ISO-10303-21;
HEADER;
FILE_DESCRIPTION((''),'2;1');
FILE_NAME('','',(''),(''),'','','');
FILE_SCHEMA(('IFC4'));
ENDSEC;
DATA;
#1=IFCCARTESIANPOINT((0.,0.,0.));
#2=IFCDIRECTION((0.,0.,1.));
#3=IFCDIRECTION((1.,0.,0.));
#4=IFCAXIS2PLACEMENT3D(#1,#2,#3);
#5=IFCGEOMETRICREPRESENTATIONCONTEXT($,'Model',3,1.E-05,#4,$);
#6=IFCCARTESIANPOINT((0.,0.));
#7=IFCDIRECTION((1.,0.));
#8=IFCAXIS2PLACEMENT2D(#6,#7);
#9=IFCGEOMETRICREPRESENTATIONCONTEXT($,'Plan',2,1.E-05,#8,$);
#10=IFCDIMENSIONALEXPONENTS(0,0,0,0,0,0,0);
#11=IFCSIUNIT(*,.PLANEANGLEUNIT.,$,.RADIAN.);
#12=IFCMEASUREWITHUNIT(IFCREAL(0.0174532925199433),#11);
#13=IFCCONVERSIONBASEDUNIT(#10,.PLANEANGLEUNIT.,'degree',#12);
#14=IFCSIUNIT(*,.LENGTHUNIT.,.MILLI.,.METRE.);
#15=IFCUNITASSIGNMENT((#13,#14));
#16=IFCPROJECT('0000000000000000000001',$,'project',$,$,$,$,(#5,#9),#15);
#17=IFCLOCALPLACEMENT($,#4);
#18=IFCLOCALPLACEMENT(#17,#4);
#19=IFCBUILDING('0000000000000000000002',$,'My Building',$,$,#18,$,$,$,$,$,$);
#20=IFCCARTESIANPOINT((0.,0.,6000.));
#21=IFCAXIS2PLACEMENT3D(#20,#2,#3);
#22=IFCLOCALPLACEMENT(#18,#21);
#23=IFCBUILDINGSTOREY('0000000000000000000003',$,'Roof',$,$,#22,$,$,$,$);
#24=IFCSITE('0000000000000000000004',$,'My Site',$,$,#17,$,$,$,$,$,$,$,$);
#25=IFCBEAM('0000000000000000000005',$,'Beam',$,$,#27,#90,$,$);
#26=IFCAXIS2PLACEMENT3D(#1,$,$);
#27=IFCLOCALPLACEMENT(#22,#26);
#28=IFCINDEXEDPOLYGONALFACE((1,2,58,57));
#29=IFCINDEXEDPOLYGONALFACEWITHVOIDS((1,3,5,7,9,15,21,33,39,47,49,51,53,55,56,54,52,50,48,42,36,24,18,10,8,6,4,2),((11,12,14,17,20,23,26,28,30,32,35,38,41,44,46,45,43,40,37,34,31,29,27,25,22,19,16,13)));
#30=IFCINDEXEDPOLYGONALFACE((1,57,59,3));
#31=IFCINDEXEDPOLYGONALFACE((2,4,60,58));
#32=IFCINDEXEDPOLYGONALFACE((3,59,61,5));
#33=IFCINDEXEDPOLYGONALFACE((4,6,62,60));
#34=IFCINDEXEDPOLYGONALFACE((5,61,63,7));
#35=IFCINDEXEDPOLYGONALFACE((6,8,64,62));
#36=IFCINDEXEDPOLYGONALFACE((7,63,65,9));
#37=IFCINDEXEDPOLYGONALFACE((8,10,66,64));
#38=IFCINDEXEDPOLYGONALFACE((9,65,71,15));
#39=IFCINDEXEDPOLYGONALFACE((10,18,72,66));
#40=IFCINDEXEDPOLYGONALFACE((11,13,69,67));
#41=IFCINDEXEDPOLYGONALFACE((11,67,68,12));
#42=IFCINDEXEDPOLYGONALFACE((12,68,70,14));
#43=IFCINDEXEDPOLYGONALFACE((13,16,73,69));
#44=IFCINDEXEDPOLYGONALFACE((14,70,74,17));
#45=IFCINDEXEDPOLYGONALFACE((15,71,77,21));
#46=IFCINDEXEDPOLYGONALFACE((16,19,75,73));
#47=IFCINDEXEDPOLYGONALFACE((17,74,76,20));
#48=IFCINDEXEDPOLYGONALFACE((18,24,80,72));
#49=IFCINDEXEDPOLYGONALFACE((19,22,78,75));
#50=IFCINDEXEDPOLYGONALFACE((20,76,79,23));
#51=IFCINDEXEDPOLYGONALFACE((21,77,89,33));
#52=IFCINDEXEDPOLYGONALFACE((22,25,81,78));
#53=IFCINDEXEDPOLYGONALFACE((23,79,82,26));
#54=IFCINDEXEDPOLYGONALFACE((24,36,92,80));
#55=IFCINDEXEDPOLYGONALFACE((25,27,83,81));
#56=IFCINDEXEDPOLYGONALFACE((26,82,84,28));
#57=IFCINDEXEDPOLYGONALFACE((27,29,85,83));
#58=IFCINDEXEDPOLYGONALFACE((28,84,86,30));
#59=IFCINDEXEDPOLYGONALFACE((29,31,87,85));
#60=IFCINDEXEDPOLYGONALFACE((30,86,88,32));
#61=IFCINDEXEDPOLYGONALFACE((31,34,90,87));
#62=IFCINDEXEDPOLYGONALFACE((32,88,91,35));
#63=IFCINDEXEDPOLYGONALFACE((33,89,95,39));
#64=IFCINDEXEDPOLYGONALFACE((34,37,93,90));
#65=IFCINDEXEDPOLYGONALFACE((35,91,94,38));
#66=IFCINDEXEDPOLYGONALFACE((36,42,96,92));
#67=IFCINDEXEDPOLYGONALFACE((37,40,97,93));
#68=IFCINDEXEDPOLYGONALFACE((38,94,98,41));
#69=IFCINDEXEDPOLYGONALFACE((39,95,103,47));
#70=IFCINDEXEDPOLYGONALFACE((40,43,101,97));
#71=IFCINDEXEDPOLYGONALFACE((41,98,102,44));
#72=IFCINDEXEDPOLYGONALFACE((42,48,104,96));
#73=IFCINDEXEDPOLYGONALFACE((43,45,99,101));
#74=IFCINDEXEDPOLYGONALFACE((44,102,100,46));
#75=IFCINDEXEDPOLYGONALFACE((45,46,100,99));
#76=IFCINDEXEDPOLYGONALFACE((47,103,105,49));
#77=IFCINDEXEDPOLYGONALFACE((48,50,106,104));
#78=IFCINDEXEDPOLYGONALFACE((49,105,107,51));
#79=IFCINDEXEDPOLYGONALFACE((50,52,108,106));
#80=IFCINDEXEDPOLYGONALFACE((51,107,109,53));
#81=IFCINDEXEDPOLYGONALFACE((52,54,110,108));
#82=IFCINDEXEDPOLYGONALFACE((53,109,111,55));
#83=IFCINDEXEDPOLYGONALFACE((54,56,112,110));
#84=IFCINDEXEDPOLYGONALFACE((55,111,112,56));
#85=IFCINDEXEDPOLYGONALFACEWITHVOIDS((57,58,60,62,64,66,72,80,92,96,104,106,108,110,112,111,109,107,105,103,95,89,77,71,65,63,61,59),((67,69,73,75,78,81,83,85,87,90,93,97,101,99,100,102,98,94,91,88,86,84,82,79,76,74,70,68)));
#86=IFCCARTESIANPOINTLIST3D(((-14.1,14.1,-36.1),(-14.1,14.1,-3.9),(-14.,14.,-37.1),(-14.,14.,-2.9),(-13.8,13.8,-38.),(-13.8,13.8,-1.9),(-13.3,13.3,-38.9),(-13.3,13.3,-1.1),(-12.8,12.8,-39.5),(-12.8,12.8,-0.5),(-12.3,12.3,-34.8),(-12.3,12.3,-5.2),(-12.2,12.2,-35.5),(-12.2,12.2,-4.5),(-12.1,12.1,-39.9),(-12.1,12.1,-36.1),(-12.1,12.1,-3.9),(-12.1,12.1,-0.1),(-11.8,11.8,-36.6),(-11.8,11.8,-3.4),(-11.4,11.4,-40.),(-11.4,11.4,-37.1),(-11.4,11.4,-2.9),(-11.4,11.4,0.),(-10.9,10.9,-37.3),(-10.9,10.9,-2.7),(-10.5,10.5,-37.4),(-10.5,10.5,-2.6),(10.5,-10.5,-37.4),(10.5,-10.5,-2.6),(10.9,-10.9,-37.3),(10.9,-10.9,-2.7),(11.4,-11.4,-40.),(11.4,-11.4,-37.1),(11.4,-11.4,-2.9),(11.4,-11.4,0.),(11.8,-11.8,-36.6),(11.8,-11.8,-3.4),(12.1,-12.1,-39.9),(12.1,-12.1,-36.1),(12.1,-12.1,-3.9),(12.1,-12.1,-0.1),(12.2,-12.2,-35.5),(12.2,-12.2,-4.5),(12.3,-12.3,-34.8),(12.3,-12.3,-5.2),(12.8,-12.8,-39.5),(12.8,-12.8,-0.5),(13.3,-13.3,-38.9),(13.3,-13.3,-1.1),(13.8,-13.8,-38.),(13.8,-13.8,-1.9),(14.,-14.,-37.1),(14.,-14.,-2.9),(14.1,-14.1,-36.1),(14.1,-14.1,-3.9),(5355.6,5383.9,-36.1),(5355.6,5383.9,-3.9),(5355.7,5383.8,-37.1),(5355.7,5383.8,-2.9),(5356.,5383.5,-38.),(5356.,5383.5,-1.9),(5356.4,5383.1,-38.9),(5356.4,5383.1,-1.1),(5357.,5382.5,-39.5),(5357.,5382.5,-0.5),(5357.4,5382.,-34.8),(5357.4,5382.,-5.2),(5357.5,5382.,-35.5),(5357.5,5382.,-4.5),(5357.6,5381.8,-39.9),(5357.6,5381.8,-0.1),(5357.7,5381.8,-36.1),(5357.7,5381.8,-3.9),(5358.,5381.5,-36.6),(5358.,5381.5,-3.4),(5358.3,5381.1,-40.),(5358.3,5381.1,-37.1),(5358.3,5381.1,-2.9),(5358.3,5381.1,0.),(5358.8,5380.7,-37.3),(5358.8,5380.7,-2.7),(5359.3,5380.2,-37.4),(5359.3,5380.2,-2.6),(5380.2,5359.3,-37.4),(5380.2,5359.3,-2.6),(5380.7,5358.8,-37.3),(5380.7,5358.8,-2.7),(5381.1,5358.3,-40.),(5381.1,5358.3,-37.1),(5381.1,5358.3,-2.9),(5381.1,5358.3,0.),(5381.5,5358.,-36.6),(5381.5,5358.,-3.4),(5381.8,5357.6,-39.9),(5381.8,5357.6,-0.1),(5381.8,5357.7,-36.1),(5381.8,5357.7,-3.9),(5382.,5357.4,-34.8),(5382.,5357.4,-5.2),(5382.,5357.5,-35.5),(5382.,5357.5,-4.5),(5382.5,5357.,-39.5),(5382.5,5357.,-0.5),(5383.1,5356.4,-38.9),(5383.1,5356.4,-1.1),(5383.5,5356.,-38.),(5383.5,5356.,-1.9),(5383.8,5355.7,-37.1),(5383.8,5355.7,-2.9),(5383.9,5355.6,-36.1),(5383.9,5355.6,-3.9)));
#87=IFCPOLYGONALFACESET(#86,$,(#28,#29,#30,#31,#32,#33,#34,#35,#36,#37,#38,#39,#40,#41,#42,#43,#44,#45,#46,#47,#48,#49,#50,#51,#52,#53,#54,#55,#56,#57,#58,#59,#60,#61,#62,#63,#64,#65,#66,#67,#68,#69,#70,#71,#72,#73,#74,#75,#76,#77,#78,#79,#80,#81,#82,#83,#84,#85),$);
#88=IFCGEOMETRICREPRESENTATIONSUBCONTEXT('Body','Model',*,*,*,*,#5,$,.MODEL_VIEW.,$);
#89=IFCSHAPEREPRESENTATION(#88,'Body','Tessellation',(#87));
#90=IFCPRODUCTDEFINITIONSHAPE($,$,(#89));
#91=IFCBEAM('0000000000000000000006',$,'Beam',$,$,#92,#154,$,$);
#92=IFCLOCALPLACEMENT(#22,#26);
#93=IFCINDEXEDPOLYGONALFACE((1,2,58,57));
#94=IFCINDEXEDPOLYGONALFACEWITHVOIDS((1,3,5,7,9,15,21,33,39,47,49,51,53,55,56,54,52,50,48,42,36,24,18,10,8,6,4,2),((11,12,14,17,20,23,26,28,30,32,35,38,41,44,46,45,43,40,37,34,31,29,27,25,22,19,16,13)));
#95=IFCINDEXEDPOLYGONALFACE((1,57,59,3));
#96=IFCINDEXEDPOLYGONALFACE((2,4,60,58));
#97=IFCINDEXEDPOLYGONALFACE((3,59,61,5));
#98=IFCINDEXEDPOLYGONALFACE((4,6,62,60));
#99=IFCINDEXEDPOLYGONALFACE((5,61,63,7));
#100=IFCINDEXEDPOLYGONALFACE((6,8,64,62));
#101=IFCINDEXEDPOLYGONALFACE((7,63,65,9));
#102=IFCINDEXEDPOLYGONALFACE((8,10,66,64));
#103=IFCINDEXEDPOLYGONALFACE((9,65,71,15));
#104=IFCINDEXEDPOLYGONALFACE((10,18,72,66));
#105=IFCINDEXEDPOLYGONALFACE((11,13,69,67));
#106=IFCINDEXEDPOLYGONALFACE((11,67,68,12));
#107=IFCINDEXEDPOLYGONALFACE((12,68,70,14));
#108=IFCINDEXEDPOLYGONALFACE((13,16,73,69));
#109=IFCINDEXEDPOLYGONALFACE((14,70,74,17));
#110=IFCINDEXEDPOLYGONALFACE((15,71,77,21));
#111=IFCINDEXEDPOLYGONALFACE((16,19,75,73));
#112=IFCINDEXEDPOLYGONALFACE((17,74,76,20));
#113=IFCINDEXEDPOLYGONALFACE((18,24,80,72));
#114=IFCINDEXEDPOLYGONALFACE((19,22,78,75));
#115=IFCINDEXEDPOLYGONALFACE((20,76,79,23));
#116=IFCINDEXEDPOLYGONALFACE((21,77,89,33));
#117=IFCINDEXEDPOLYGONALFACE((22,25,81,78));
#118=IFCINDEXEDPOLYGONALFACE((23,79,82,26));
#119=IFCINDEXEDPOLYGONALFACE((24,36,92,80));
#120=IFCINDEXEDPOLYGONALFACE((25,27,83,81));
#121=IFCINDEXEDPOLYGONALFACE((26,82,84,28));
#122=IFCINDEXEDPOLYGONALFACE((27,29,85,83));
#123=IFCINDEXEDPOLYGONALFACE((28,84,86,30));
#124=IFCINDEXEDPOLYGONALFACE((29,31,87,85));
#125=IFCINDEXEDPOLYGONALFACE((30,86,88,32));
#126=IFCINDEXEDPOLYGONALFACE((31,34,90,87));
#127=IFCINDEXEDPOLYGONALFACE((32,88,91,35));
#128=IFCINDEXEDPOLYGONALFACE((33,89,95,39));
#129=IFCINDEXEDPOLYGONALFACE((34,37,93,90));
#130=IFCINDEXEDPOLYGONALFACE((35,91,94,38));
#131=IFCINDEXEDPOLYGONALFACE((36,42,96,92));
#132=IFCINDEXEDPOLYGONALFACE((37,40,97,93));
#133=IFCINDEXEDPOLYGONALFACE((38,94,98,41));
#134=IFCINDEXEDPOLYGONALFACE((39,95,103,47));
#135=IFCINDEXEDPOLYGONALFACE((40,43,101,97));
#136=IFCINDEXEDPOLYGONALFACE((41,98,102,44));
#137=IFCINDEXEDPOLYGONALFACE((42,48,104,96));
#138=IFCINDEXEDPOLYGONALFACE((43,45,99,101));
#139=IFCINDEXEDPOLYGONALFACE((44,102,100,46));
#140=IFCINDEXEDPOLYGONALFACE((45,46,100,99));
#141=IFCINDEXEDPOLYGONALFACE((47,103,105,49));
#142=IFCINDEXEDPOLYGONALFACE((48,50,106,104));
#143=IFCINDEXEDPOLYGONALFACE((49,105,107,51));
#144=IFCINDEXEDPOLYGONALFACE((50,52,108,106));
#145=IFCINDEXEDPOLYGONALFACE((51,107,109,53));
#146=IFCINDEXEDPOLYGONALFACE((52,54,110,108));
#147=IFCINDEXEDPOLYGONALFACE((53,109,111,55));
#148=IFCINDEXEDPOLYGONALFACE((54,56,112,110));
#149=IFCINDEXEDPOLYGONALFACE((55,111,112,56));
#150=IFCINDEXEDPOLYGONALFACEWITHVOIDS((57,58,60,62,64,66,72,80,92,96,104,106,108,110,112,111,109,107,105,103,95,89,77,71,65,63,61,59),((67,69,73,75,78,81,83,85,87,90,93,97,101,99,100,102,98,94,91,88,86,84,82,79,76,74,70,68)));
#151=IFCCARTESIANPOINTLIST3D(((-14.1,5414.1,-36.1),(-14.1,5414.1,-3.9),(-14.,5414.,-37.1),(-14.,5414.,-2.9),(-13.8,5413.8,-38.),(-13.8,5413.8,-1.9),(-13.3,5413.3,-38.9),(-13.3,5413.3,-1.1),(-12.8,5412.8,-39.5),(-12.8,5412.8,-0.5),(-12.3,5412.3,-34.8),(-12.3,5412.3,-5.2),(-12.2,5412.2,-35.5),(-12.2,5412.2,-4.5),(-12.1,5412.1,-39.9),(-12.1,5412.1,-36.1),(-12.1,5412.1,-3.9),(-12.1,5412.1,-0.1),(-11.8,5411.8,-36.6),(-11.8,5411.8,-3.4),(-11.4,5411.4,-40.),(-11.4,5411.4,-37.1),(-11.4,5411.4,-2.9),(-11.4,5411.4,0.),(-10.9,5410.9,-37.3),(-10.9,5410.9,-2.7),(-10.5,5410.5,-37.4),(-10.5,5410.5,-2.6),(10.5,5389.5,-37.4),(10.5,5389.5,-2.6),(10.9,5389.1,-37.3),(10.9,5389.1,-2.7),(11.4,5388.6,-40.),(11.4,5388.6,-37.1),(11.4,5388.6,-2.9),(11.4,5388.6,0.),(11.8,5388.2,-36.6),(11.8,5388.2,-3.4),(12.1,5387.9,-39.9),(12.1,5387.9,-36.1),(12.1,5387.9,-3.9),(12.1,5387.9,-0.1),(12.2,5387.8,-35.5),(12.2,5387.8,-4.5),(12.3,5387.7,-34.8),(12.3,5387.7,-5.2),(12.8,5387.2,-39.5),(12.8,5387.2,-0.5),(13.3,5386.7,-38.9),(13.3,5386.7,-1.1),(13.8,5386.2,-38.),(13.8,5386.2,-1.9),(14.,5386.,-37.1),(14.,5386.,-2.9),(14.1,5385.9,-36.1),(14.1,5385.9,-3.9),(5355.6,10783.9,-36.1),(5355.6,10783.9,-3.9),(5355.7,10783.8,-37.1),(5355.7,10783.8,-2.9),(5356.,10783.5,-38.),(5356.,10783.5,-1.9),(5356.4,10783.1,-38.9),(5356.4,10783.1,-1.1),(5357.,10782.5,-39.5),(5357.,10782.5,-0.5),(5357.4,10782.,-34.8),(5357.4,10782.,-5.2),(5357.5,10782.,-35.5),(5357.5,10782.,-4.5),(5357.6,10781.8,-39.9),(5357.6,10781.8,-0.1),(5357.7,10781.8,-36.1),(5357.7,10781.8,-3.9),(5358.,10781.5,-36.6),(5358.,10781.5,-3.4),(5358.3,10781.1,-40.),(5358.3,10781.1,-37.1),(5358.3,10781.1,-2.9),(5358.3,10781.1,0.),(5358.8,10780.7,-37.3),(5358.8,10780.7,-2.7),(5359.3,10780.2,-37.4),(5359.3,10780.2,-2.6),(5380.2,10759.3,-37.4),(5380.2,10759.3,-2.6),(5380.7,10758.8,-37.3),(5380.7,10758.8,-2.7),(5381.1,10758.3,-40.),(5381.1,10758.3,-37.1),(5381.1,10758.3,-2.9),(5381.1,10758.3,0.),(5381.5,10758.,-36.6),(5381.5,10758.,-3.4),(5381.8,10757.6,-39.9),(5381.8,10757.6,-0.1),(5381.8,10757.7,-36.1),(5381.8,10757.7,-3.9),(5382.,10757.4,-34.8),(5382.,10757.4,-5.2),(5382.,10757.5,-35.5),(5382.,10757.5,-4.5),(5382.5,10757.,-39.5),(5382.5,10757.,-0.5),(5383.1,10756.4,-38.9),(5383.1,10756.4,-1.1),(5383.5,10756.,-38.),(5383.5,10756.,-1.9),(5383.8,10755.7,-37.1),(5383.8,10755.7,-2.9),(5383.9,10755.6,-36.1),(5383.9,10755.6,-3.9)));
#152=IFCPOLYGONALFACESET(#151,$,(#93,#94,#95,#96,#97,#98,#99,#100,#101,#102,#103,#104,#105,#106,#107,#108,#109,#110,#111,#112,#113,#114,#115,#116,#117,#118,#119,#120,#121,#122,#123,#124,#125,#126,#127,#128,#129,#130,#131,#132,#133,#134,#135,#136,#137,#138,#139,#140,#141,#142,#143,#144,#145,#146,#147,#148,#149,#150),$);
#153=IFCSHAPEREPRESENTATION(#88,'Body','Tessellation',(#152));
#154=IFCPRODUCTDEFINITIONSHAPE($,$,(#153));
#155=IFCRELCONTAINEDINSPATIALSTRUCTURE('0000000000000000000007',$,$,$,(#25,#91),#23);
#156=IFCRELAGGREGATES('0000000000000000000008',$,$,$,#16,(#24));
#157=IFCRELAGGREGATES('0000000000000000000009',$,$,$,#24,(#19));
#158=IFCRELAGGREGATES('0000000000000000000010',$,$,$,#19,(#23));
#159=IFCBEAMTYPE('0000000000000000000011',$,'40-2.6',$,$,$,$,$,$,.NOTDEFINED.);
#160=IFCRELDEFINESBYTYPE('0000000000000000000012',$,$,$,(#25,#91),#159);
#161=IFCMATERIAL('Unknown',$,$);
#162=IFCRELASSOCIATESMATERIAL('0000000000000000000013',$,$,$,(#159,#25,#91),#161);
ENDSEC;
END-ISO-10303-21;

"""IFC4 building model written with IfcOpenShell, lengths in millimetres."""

from ifc_helpers import new_model, entity, si_unit, converted_unit, frame, origin_with_axes, origin_2d_with_axis, place, context, subcontext, project, spatial, hollow_rectangle, extrude, material, material_profile, profile_set, profile_usage, type_object, element, save


model = new_model("IFC4")

# Units and contexts
model_context = context("Model", 3, precision=1e-05, world=origin_with_axes())
plan_context = context("Plan", 2, precision=1e-05, world=origin_2d_with_axis())
body_context = subcontext(model_context, "Body", "Model", "MODEL_VIEW")
ifc_project = project(units=[converted_unit("PLANEANGLEUNIT", "degree", entity("IfcReal", 0.0174532925199433), si_unit("PLANEANGLEUNIT", "RADIAN"), dimensions=[0, 0, 0, 0, 0, 0, 0]), si_unit("LENGTHUNIT", "METRE", prefix="MILLI")], contexts=[model_context, plan_context])

# Site, building, storey
site_placement = place(None, origin_with_axes())
site = spatial("IfcSite", under=ifc_project, at=site_placement, Name="My Site")
building_placement = place(site_placement, origin_with_axes())
building = spatial("IfcBuilding", under=site, at=building_placement, Name="My Building")
storey_placement = place(building_placement, frame((0.0, 0.0, 6000.0), z_axis=(0.0, 0.0, 1.0), x_axis=(1.0, 0.0, 0.0)))
storey = spatial("IfcBuildingStorey", under=building, at=storey_placement, Name="Roof")

# Beams
ifc_material = material(Name="Unknown")
ifc_material_profile_1 = material_profile(ifc_material, hollow_rectangle(XDim=40.0, YDim=40.0, WallThickness=2.6, InnerFilletRadius=2.6, OuterFilletRadius=3.9))
ifc_profile_set_1 = profile_set([ifc_material_profile_1])
ifc_profile_usage_1 = profile_usage(ifc_profile_set_1, cardinal=8)
beam_type_1 = type_object("IfcBeamType", Name="40-2.6", PredefinedType="NOTDEFINED", material=ifc_profile_set_1)
beam_1_placement = place(storey_placement, frame((0.0, 0.0, 0.0), z_axis=(0.707107, 0.707107, 0.0), x_axis=(-0.707107, 0.707107, 0.0)))
element("IfcBeam", 1, at=beam_1_placement, inside=storey, type_object=beam_type_1, material=ifc_profile_usage_1, Name="Beam", context=body_context, shape_type="SweptSolid", body=[
    extrude(hollow_rectangle(XDim=40.0, YDim=40.0, WallThickness=2.6, InnerFilletRadius=2.6, OuterFilletRadius=3.9), frame((0.0, -20.0, 0.0), z_axis=(0.0, 0.0, 1.0), x_axis=(1.0, 0.0, 0.0)), (0.0, 0.0, 1.0), 7594.0),
])
ifc_profile_usage_2 = profile_usage(ifc_profile_set_1, cardinal=8)
beam_2_placement = place(storey_placement, frame((0.0, 5400.0, 0.0), z_axis=(0.707107, 0.707107, 0.0), x_axis=(-0.707107, 0.707107, 0.0)))
element("IfcBeam", 2, at=beam_2_placement, inside=storey, type_object=beam_type_1, material=ifc_profile_usage_2, Name="Beam", context=body_context, shape_type="SweptSolid", body=[
    extrude(hollow_rectangle(XDim=40.0, YDim=40.0, WallThickness=2.6, InnerFilletRadius=2.6, OuterFilletRadius=3.9), frame((0.0, -20.0, 0.0), z_axis=(0.0, 0.0, 1.0), x_axis=(1.0, 0.0, 0.0)), (0.0, 0.0, 1.0), 7594.0),
])

save(model, "model.ifc")
